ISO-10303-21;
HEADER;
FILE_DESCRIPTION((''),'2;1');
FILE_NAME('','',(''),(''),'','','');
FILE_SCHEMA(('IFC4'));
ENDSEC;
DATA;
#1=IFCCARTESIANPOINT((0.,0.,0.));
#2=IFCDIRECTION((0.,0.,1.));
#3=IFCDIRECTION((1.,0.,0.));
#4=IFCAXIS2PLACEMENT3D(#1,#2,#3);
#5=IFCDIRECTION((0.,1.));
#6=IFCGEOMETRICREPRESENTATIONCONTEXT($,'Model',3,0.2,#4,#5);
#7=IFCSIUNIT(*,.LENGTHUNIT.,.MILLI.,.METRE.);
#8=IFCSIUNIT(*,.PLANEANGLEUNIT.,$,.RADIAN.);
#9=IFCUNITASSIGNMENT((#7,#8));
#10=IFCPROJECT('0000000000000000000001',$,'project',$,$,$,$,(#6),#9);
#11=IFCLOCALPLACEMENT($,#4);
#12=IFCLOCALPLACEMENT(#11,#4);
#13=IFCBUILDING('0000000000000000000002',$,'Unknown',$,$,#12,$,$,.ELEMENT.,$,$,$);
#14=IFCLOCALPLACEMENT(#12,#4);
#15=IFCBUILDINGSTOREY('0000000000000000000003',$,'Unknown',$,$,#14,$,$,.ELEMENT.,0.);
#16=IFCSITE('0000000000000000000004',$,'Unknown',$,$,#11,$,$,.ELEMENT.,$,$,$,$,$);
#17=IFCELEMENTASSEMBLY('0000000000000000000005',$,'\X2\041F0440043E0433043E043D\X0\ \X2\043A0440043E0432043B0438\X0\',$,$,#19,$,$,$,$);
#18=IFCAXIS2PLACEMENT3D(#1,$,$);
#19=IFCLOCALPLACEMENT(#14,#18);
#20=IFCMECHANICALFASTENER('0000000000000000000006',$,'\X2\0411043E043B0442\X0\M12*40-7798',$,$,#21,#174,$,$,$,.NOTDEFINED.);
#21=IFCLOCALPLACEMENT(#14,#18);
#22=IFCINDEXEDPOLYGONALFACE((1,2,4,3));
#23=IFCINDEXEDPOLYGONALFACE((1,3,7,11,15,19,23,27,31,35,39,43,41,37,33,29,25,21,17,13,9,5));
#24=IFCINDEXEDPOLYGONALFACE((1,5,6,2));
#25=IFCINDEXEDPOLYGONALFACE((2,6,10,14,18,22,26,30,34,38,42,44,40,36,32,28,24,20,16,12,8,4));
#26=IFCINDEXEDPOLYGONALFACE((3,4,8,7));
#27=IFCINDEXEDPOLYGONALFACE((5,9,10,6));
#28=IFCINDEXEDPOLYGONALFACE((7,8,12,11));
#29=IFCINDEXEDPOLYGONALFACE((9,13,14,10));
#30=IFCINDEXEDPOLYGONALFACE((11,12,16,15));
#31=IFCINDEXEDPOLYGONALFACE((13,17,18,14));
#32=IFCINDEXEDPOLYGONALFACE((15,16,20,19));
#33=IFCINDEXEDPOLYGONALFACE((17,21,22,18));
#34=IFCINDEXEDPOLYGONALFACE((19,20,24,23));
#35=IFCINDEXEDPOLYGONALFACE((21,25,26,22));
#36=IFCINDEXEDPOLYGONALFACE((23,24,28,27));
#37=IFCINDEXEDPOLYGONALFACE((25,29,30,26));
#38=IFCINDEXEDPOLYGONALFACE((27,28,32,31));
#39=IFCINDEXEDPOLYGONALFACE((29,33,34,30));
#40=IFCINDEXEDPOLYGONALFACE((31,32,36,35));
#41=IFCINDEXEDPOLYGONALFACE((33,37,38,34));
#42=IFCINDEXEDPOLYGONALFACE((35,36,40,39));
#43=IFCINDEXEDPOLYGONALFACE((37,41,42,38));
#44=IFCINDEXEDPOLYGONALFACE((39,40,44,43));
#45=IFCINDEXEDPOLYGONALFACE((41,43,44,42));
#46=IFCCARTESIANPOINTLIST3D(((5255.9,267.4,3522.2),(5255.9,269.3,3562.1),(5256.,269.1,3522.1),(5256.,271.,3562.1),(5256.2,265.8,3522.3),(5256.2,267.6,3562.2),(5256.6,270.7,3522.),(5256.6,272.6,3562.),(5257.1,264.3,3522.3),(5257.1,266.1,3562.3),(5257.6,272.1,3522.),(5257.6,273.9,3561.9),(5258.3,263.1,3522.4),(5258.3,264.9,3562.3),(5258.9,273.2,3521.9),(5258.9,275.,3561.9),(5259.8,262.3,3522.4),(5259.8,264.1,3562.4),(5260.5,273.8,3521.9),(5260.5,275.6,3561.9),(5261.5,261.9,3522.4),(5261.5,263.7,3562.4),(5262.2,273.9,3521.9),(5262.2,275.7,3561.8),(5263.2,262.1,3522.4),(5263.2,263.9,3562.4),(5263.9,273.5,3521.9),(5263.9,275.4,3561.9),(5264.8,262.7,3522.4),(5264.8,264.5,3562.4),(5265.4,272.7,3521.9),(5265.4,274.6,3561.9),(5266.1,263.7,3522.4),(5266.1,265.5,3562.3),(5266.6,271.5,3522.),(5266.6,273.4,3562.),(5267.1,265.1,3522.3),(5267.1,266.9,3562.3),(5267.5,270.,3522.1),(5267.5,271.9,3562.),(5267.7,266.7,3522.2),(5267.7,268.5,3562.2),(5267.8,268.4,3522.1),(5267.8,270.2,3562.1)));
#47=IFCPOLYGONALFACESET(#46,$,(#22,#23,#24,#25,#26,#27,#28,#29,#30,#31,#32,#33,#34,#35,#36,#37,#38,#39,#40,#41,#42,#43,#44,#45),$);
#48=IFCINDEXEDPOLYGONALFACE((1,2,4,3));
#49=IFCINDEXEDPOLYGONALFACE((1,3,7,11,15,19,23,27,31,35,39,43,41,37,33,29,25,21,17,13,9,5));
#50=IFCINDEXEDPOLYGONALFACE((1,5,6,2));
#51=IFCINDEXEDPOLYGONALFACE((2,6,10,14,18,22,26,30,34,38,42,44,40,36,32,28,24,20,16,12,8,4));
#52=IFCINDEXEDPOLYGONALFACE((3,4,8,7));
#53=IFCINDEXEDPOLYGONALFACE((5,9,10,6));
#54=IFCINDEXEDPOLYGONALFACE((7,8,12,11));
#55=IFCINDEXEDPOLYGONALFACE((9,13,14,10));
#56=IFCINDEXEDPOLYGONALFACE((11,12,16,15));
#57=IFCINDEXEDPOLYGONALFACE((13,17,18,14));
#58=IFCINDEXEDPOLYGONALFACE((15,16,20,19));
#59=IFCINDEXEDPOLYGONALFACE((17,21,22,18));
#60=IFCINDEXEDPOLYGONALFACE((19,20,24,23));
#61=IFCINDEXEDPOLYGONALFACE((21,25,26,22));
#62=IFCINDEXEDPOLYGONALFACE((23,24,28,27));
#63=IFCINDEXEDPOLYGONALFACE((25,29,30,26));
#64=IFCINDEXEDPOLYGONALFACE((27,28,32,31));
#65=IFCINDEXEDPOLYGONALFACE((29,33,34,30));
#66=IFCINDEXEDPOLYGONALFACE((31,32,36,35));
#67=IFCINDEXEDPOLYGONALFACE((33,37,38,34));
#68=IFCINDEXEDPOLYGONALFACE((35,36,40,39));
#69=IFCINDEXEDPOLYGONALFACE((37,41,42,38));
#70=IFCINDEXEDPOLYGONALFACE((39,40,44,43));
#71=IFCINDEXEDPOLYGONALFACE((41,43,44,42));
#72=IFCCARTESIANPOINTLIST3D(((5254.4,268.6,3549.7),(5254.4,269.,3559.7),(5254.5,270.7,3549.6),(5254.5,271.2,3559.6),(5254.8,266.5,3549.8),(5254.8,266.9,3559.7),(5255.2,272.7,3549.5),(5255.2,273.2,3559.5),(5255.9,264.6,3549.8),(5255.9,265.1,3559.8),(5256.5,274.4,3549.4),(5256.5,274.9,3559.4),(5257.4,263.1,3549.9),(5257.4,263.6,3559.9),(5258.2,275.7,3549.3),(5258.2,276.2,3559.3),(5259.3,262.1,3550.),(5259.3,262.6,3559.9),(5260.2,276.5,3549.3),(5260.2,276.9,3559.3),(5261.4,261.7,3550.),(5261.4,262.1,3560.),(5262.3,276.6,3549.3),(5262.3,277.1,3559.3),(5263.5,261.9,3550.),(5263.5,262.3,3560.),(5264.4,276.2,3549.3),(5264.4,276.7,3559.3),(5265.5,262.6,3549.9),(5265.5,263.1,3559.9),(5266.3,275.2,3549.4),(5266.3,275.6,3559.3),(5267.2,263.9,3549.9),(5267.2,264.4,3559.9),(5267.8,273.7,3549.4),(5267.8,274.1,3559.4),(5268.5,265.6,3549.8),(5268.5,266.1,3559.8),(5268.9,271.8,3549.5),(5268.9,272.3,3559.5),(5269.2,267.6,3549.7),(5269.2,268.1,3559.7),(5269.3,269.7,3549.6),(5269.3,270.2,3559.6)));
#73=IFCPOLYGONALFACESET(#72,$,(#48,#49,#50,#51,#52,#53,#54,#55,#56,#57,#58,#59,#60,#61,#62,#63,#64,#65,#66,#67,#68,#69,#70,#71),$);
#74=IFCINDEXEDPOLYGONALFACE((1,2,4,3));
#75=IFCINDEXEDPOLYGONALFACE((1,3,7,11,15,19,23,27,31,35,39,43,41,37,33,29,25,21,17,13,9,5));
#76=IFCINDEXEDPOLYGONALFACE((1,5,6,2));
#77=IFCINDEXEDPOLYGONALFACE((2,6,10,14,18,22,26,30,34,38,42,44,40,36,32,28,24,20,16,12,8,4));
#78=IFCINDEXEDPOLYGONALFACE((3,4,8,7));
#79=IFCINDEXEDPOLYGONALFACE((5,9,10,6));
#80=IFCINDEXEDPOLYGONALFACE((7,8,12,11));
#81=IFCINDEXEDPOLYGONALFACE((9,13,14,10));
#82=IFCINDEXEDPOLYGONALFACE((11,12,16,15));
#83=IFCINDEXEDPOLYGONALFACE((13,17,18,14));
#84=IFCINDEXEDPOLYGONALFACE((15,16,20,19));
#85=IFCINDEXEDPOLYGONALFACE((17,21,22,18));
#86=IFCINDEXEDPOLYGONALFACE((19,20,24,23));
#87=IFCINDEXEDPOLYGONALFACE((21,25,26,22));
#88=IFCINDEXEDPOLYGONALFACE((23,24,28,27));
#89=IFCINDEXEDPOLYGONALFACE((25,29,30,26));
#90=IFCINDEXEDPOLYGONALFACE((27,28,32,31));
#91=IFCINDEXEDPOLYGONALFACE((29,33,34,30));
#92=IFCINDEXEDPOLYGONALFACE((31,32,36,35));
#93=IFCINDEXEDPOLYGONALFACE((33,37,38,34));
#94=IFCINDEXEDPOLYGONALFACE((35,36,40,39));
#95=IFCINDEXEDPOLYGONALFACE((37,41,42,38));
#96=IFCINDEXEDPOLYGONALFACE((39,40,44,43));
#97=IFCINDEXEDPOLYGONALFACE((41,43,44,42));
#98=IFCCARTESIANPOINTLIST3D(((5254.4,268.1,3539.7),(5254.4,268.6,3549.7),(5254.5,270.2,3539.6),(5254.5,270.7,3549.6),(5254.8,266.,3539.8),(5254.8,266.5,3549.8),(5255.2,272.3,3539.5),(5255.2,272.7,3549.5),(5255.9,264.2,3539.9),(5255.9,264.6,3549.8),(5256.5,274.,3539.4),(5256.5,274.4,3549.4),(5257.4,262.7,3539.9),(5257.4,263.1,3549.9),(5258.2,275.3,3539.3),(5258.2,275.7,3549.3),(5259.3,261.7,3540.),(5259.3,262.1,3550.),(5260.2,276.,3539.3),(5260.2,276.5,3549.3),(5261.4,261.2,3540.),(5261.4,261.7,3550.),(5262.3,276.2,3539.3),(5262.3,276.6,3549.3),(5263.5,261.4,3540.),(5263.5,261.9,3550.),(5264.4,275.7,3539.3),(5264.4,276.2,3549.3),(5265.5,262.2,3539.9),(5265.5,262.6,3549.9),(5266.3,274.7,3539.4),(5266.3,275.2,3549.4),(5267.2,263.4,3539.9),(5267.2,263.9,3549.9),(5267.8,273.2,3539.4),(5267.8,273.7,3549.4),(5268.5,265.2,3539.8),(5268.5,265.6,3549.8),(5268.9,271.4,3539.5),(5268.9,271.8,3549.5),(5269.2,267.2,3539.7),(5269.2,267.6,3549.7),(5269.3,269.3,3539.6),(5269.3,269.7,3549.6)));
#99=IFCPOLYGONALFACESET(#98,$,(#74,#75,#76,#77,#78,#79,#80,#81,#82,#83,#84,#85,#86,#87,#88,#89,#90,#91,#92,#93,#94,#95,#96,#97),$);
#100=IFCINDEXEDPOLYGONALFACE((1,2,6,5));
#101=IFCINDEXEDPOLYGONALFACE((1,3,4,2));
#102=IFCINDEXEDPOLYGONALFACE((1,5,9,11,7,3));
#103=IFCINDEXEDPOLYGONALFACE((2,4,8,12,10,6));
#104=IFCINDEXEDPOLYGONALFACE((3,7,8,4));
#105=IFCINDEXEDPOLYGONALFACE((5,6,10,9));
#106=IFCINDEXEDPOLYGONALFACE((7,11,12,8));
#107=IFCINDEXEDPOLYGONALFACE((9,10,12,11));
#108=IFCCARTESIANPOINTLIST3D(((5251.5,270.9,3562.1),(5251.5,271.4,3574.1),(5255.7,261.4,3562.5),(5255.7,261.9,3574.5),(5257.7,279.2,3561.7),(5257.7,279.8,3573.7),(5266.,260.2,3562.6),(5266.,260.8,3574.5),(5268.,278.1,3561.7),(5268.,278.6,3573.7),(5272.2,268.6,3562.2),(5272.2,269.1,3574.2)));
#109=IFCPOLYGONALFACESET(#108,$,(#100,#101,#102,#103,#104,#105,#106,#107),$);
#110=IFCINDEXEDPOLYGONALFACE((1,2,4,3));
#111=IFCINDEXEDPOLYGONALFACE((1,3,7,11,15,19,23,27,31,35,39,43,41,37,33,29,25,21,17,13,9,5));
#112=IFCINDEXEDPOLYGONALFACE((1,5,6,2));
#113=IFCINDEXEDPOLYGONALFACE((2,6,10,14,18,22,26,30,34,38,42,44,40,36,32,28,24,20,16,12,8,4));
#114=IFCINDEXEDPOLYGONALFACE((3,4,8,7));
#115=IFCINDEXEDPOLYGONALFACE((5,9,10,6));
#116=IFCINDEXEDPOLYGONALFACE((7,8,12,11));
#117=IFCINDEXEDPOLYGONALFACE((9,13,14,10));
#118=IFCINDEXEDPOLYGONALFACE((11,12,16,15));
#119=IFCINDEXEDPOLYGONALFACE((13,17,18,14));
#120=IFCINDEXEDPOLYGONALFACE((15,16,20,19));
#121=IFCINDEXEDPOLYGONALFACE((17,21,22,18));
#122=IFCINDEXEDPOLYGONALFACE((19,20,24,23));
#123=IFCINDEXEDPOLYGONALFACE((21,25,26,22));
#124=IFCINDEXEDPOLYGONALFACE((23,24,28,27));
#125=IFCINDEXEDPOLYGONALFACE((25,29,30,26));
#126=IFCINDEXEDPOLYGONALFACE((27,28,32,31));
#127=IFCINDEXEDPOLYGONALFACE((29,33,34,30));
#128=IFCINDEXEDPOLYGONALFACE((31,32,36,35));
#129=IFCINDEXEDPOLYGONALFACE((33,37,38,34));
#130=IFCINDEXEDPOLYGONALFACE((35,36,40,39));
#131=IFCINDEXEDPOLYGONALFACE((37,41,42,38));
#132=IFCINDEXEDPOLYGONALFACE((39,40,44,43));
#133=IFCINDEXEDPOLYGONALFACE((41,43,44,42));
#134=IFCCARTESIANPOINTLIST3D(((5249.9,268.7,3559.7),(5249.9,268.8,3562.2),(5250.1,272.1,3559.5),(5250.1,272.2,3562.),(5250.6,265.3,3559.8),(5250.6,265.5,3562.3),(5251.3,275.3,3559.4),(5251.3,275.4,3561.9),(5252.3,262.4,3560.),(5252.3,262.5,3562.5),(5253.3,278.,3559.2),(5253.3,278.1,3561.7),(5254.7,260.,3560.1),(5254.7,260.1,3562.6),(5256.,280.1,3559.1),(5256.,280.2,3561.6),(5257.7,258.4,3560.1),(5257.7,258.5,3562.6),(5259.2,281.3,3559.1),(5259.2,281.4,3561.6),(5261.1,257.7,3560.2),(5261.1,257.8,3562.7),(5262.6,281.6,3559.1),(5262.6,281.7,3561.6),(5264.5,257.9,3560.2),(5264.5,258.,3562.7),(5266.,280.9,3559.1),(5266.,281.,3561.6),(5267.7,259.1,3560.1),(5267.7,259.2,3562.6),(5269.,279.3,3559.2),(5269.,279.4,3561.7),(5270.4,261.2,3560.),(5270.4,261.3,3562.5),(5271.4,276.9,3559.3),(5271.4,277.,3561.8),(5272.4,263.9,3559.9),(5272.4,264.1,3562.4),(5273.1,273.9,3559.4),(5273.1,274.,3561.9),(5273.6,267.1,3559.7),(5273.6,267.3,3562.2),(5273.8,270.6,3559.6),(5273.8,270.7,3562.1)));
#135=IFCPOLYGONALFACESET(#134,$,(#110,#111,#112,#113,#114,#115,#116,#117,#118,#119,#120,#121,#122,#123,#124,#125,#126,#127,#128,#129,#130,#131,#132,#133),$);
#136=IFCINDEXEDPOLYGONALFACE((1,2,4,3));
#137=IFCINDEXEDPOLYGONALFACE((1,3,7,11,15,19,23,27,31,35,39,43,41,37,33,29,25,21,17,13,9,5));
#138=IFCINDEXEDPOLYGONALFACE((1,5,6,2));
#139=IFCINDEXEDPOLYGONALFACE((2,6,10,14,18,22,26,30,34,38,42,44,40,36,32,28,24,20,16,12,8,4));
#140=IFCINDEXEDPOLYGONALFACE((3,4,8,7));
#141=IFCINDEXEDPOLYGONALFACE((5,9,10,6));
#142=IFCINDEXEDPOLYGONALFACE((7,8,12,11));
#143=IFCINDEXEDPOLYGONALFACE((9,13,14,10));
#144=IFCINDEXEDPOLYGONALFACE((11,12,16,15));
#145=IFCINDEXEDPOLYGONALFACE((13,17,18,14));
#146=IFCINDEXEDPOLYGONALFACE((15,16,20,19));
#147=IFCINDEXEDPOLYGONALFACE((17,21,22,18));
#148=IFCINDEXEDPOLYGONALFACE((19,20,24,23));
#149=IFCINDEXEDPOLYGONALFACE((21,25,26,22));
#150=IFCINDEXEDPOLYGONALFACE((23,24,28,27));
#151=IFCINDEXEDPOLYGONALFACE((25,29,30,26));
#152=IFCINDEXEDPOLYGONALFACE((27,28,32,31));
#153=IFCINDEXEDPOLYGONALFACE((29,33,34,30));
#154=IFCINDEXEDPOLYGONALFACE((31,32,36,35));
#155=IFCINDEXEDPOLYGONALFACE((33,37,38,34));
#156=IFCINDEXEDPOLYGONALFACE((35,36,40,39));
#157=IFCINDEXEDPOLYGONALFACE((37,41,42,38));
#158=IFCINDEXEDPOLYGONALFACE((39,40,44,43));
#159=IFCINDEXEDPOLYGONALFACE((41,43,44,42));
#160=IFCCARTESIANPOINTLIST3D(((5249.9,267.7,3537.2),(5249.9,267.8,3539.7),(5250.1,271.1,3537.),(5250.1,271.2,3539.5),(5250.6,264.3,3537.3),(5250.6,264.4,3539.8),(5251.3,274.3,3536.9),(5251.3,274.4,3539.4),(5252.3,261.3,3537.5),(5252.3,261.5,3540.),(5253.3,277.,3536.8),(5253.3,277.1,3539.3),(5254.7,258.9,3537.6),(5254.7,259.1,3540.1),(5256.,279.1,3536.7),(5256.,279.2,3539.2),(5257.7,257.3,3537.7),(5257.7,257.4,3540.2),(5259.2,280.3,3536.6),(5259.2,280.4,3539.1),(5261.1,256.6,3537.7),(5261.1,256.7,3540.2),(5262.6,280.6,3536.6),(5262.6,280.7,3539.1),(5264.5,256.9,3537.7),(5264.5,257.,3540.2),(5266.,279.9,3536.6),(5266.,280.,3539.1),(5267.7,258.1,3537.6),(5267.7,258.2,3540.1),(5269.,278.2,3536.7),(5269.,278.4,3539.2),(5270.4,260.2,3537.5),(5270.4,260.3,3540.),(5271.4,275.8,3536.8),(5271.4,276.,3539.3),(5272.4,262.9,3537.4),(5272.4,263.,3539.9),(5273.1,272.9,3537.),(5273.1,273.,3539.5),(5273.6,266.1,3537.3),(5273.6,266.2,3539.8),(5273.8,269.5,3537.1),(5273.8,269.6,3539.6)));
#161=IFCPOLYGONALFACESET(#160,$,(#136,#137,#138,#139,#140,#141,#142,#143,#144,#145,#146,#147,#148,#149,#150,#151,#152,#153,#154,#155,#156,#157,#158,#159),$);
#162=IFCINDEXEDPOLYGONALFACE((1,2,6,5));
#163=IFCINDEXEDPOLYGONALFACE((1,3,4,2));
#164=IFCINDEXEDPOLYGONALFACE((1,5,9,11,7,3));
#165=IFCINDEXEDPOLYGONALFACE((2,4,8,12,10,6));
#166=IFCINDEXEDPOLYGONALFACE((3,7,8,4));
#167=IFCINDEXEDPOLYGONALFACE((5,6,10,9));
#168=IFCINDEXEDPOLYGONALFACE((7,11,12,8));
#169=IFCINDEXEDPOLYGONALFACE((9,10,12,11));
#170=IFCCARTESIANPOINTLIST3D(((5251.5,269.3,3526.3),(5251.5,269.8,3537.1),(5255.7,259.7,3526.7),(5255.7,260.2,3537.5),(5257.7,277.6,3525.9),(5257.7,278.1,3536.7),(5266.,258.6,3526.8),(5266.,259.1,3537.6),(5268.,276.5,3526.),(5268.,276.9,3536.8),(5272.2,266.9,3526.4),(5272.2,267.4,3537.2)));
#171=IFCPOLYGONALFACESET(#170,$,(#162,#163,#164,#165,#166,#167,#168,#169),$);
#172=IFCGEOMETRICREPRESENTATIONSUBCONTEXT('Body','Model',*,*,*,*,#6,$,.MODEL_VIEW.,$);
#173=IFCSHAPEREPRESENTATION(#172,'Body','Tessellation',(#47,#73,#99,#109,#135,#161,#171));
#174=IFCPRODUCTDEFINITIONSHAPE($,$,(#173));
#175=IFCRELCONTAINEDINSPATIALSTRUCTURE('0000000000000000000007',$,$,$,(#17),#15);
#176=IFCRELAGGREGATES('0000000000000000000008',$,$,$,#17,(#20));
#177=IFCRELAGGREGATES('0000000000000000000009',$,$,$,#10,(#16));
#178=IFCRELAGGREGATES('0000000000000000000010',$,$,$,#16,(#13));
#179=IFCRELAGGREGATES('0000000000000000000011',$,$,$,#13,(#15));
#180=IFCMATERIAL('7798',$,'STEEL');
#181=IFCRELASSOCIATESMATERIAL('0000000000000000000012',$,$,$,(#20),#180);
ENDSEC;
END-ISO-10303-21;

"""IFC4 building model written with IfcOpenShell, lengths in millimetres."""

from ifc_helpers import new_model, si_unit, direction, frame, origin_with_axes, place, context, subcontext, project, spatial, line, arc, indexed_curve, outline, extrude, source, transform, mapped, material, element, aggregate, save


model = new_model("IFC4")

# Units and contexts
model_context = context("Model", 3, precision=0.2, world=origin_with_axes(), true_north=direction((0.0, 1.0)))
body_context = subcontext(model_context, "Body", "Model", "MODEL_VIEW")
ifc_project = project(units=[si_unit("LENGTHUNIT", "METRE", prefix="MILLI"), si_unit("PLANEANGLEUNIT", "RADIAN")], contexts=[model_context])

# Site, building, storey
site_placement = place(None, origin_with_axes())
site = spatial("IfcSite", under=ifc_project, at=site_placement, Name="Unknown", CompositionType="ELEMENT")
building_placement = place(site_placement, origin_with_axes())
building = spatial("IfcBuilding", under=site, at=building_placement, Name="Unknown", CompositionType="ELEMENT")
storey_placement = place(building_placement, origin_with_axes())
storey = spatial("IfcBuildingStorey", under=building, at=storey_placement, Name="Unknown", CompositionType="ELEMENT", Elevation=0.0)

# Element assembly
assembly_1_placement = place(storey_placement, frame((-595.0, 167.1, 3549.3), z_axis=(0.0, -0.998969, 0.045408), x_axis=(1.0, 0.0, 0.0)))
assembly_1 = element("IfcElementAssembly", 1, at=assembly_1_placement, inside=storey, Name="Прогон кровли")

# Mechanical fastener
ifc_material_1 = material(Name="7798", Category="STEEL")
shared_shape_1 = source(origin_with_axes(), body_context, "Body", "SweptSolid", [
    extrude(outline(indexed_curve([(6.0, 0.0), (0.0, 6.0), (-6.0, 0.0), (0.0, -6.0)], segments=[arc(1, 2, 3), arc(3, 4, 1)])), frame((0.0, 0.0, 12.5), z_axis=(0.0, 0.0, -1.0), x_axis=(0.0, 1.0, 0.0)), (0.0, 0.0, 1.0), 40.0),
    extrude(outline(indexed_curve([(7.5, 0.0), (0.0, 7.5), (-7.5, 0.0), (0.0, -7.5)], segments=[arc(1, 2, 3), arc(3, 4, 1)])), frame((0.0, 0.0, 10.0), z_axis=(0.0, 0.0, -1.0), x_axis=(0.0, 1.0, 0.0)), (0.0, 0.0, 1.0), 10.0),
    extrude(outline(indexed_curve([(7.5, 0.0), (0.0, 7.5), (-7.5, 0.0), (0.0, -7.5)], segments=[arc(1, 2, 3), arc(3, 4, 1)])), frame((0.0, 0.0, 0.0), z_axis=(0.0, 0.0, -1.0), x_axis=(0.0, 1.0, 0.0)), (0.0, 0.0, 1.0), 10.0),
    extrude(outline(indexed_curve([(10.4, 0.0), (5.2, 9.0), (-5.2, 9.0), (-10.4, 0.0), (-5.2, -9.0), (5.2, -9.0)], segments=[line(1, 2, 3, 4, 5, 6, 1)])), frame((0.0, 0.0, 24.5), z_axis=(0.0, 0.0, -1.0), x_axis=(0.0, 1.0, 0.0)), (0.0, 0.0, 1.0), 12.0),
    extrude(outline(indexed_curve([(12.0, 0.0), (0.0, 12.0), (-12.0, 0.0), (0.0, -12.0)], segments=[arc(1, 2, 3), arc(3, 4, 1)])), frame((0.0, 0.0, 12.5), z_axis=(0.0, 0.0, -1.0), x_axis=(0.0, 1.0, 0.0)), (0.0, 0.0, 1.0), 2.5),
    extrude(outline(indexed_curve([(12.0, 0.0), (0.0, 12.0), (-12.0, 0.0), (0.0, -12.0)], segments=[arc(1, 2, 3), arc(3, 4, 1)])), frame((0.0, 0.0, -10.0), z_axis=(0.0, 0.0, -1.0), x_axis=(0.0, 1.0, 0.0)), (0.0, 0.0, 1.0), 2.5),
    extrude(outline(indexed_curve([(10.4, 0.0), (5.2, 9.0), (-5.2, 9.0), (-10.4, 0.0), (-5.2, -9.0), (5.2, -9.0)], segments=[line(1, 2, 3, 4, 5, 6, 1)])), frame((0.0, 0.0, -12.5), z_axis=(0.0, 0.0, -1.0), x_axis=(0.0, 1.0, 0.0)), (0.0, 0.0, 1.0), 10.8),
])
mechanical_fastener_1_placement = place(assembly_1_placement, frame((5856.9, 5.0, -102.0), z_axis=(0.0, 1.0, 0.0), x_axis=(-0.804616, 0.0, -0.593795)))
mechanical_fastener_1 = element("IfcMechanicalFastener", 2, at=mechanical_fastener_1_placement, material=ifc_material_1, Name="БолтM12*40-7798", PredefinedType="NOTDEFINED", context=body_context, shape_type="MappedRepresentation", body=[
    mapped(shared_shape_1, transform((0.0, 0.0, 0.0))),
])
aggregate(assembly_1, [mechanical_fastener_1])

save(model, "model.ifc")
